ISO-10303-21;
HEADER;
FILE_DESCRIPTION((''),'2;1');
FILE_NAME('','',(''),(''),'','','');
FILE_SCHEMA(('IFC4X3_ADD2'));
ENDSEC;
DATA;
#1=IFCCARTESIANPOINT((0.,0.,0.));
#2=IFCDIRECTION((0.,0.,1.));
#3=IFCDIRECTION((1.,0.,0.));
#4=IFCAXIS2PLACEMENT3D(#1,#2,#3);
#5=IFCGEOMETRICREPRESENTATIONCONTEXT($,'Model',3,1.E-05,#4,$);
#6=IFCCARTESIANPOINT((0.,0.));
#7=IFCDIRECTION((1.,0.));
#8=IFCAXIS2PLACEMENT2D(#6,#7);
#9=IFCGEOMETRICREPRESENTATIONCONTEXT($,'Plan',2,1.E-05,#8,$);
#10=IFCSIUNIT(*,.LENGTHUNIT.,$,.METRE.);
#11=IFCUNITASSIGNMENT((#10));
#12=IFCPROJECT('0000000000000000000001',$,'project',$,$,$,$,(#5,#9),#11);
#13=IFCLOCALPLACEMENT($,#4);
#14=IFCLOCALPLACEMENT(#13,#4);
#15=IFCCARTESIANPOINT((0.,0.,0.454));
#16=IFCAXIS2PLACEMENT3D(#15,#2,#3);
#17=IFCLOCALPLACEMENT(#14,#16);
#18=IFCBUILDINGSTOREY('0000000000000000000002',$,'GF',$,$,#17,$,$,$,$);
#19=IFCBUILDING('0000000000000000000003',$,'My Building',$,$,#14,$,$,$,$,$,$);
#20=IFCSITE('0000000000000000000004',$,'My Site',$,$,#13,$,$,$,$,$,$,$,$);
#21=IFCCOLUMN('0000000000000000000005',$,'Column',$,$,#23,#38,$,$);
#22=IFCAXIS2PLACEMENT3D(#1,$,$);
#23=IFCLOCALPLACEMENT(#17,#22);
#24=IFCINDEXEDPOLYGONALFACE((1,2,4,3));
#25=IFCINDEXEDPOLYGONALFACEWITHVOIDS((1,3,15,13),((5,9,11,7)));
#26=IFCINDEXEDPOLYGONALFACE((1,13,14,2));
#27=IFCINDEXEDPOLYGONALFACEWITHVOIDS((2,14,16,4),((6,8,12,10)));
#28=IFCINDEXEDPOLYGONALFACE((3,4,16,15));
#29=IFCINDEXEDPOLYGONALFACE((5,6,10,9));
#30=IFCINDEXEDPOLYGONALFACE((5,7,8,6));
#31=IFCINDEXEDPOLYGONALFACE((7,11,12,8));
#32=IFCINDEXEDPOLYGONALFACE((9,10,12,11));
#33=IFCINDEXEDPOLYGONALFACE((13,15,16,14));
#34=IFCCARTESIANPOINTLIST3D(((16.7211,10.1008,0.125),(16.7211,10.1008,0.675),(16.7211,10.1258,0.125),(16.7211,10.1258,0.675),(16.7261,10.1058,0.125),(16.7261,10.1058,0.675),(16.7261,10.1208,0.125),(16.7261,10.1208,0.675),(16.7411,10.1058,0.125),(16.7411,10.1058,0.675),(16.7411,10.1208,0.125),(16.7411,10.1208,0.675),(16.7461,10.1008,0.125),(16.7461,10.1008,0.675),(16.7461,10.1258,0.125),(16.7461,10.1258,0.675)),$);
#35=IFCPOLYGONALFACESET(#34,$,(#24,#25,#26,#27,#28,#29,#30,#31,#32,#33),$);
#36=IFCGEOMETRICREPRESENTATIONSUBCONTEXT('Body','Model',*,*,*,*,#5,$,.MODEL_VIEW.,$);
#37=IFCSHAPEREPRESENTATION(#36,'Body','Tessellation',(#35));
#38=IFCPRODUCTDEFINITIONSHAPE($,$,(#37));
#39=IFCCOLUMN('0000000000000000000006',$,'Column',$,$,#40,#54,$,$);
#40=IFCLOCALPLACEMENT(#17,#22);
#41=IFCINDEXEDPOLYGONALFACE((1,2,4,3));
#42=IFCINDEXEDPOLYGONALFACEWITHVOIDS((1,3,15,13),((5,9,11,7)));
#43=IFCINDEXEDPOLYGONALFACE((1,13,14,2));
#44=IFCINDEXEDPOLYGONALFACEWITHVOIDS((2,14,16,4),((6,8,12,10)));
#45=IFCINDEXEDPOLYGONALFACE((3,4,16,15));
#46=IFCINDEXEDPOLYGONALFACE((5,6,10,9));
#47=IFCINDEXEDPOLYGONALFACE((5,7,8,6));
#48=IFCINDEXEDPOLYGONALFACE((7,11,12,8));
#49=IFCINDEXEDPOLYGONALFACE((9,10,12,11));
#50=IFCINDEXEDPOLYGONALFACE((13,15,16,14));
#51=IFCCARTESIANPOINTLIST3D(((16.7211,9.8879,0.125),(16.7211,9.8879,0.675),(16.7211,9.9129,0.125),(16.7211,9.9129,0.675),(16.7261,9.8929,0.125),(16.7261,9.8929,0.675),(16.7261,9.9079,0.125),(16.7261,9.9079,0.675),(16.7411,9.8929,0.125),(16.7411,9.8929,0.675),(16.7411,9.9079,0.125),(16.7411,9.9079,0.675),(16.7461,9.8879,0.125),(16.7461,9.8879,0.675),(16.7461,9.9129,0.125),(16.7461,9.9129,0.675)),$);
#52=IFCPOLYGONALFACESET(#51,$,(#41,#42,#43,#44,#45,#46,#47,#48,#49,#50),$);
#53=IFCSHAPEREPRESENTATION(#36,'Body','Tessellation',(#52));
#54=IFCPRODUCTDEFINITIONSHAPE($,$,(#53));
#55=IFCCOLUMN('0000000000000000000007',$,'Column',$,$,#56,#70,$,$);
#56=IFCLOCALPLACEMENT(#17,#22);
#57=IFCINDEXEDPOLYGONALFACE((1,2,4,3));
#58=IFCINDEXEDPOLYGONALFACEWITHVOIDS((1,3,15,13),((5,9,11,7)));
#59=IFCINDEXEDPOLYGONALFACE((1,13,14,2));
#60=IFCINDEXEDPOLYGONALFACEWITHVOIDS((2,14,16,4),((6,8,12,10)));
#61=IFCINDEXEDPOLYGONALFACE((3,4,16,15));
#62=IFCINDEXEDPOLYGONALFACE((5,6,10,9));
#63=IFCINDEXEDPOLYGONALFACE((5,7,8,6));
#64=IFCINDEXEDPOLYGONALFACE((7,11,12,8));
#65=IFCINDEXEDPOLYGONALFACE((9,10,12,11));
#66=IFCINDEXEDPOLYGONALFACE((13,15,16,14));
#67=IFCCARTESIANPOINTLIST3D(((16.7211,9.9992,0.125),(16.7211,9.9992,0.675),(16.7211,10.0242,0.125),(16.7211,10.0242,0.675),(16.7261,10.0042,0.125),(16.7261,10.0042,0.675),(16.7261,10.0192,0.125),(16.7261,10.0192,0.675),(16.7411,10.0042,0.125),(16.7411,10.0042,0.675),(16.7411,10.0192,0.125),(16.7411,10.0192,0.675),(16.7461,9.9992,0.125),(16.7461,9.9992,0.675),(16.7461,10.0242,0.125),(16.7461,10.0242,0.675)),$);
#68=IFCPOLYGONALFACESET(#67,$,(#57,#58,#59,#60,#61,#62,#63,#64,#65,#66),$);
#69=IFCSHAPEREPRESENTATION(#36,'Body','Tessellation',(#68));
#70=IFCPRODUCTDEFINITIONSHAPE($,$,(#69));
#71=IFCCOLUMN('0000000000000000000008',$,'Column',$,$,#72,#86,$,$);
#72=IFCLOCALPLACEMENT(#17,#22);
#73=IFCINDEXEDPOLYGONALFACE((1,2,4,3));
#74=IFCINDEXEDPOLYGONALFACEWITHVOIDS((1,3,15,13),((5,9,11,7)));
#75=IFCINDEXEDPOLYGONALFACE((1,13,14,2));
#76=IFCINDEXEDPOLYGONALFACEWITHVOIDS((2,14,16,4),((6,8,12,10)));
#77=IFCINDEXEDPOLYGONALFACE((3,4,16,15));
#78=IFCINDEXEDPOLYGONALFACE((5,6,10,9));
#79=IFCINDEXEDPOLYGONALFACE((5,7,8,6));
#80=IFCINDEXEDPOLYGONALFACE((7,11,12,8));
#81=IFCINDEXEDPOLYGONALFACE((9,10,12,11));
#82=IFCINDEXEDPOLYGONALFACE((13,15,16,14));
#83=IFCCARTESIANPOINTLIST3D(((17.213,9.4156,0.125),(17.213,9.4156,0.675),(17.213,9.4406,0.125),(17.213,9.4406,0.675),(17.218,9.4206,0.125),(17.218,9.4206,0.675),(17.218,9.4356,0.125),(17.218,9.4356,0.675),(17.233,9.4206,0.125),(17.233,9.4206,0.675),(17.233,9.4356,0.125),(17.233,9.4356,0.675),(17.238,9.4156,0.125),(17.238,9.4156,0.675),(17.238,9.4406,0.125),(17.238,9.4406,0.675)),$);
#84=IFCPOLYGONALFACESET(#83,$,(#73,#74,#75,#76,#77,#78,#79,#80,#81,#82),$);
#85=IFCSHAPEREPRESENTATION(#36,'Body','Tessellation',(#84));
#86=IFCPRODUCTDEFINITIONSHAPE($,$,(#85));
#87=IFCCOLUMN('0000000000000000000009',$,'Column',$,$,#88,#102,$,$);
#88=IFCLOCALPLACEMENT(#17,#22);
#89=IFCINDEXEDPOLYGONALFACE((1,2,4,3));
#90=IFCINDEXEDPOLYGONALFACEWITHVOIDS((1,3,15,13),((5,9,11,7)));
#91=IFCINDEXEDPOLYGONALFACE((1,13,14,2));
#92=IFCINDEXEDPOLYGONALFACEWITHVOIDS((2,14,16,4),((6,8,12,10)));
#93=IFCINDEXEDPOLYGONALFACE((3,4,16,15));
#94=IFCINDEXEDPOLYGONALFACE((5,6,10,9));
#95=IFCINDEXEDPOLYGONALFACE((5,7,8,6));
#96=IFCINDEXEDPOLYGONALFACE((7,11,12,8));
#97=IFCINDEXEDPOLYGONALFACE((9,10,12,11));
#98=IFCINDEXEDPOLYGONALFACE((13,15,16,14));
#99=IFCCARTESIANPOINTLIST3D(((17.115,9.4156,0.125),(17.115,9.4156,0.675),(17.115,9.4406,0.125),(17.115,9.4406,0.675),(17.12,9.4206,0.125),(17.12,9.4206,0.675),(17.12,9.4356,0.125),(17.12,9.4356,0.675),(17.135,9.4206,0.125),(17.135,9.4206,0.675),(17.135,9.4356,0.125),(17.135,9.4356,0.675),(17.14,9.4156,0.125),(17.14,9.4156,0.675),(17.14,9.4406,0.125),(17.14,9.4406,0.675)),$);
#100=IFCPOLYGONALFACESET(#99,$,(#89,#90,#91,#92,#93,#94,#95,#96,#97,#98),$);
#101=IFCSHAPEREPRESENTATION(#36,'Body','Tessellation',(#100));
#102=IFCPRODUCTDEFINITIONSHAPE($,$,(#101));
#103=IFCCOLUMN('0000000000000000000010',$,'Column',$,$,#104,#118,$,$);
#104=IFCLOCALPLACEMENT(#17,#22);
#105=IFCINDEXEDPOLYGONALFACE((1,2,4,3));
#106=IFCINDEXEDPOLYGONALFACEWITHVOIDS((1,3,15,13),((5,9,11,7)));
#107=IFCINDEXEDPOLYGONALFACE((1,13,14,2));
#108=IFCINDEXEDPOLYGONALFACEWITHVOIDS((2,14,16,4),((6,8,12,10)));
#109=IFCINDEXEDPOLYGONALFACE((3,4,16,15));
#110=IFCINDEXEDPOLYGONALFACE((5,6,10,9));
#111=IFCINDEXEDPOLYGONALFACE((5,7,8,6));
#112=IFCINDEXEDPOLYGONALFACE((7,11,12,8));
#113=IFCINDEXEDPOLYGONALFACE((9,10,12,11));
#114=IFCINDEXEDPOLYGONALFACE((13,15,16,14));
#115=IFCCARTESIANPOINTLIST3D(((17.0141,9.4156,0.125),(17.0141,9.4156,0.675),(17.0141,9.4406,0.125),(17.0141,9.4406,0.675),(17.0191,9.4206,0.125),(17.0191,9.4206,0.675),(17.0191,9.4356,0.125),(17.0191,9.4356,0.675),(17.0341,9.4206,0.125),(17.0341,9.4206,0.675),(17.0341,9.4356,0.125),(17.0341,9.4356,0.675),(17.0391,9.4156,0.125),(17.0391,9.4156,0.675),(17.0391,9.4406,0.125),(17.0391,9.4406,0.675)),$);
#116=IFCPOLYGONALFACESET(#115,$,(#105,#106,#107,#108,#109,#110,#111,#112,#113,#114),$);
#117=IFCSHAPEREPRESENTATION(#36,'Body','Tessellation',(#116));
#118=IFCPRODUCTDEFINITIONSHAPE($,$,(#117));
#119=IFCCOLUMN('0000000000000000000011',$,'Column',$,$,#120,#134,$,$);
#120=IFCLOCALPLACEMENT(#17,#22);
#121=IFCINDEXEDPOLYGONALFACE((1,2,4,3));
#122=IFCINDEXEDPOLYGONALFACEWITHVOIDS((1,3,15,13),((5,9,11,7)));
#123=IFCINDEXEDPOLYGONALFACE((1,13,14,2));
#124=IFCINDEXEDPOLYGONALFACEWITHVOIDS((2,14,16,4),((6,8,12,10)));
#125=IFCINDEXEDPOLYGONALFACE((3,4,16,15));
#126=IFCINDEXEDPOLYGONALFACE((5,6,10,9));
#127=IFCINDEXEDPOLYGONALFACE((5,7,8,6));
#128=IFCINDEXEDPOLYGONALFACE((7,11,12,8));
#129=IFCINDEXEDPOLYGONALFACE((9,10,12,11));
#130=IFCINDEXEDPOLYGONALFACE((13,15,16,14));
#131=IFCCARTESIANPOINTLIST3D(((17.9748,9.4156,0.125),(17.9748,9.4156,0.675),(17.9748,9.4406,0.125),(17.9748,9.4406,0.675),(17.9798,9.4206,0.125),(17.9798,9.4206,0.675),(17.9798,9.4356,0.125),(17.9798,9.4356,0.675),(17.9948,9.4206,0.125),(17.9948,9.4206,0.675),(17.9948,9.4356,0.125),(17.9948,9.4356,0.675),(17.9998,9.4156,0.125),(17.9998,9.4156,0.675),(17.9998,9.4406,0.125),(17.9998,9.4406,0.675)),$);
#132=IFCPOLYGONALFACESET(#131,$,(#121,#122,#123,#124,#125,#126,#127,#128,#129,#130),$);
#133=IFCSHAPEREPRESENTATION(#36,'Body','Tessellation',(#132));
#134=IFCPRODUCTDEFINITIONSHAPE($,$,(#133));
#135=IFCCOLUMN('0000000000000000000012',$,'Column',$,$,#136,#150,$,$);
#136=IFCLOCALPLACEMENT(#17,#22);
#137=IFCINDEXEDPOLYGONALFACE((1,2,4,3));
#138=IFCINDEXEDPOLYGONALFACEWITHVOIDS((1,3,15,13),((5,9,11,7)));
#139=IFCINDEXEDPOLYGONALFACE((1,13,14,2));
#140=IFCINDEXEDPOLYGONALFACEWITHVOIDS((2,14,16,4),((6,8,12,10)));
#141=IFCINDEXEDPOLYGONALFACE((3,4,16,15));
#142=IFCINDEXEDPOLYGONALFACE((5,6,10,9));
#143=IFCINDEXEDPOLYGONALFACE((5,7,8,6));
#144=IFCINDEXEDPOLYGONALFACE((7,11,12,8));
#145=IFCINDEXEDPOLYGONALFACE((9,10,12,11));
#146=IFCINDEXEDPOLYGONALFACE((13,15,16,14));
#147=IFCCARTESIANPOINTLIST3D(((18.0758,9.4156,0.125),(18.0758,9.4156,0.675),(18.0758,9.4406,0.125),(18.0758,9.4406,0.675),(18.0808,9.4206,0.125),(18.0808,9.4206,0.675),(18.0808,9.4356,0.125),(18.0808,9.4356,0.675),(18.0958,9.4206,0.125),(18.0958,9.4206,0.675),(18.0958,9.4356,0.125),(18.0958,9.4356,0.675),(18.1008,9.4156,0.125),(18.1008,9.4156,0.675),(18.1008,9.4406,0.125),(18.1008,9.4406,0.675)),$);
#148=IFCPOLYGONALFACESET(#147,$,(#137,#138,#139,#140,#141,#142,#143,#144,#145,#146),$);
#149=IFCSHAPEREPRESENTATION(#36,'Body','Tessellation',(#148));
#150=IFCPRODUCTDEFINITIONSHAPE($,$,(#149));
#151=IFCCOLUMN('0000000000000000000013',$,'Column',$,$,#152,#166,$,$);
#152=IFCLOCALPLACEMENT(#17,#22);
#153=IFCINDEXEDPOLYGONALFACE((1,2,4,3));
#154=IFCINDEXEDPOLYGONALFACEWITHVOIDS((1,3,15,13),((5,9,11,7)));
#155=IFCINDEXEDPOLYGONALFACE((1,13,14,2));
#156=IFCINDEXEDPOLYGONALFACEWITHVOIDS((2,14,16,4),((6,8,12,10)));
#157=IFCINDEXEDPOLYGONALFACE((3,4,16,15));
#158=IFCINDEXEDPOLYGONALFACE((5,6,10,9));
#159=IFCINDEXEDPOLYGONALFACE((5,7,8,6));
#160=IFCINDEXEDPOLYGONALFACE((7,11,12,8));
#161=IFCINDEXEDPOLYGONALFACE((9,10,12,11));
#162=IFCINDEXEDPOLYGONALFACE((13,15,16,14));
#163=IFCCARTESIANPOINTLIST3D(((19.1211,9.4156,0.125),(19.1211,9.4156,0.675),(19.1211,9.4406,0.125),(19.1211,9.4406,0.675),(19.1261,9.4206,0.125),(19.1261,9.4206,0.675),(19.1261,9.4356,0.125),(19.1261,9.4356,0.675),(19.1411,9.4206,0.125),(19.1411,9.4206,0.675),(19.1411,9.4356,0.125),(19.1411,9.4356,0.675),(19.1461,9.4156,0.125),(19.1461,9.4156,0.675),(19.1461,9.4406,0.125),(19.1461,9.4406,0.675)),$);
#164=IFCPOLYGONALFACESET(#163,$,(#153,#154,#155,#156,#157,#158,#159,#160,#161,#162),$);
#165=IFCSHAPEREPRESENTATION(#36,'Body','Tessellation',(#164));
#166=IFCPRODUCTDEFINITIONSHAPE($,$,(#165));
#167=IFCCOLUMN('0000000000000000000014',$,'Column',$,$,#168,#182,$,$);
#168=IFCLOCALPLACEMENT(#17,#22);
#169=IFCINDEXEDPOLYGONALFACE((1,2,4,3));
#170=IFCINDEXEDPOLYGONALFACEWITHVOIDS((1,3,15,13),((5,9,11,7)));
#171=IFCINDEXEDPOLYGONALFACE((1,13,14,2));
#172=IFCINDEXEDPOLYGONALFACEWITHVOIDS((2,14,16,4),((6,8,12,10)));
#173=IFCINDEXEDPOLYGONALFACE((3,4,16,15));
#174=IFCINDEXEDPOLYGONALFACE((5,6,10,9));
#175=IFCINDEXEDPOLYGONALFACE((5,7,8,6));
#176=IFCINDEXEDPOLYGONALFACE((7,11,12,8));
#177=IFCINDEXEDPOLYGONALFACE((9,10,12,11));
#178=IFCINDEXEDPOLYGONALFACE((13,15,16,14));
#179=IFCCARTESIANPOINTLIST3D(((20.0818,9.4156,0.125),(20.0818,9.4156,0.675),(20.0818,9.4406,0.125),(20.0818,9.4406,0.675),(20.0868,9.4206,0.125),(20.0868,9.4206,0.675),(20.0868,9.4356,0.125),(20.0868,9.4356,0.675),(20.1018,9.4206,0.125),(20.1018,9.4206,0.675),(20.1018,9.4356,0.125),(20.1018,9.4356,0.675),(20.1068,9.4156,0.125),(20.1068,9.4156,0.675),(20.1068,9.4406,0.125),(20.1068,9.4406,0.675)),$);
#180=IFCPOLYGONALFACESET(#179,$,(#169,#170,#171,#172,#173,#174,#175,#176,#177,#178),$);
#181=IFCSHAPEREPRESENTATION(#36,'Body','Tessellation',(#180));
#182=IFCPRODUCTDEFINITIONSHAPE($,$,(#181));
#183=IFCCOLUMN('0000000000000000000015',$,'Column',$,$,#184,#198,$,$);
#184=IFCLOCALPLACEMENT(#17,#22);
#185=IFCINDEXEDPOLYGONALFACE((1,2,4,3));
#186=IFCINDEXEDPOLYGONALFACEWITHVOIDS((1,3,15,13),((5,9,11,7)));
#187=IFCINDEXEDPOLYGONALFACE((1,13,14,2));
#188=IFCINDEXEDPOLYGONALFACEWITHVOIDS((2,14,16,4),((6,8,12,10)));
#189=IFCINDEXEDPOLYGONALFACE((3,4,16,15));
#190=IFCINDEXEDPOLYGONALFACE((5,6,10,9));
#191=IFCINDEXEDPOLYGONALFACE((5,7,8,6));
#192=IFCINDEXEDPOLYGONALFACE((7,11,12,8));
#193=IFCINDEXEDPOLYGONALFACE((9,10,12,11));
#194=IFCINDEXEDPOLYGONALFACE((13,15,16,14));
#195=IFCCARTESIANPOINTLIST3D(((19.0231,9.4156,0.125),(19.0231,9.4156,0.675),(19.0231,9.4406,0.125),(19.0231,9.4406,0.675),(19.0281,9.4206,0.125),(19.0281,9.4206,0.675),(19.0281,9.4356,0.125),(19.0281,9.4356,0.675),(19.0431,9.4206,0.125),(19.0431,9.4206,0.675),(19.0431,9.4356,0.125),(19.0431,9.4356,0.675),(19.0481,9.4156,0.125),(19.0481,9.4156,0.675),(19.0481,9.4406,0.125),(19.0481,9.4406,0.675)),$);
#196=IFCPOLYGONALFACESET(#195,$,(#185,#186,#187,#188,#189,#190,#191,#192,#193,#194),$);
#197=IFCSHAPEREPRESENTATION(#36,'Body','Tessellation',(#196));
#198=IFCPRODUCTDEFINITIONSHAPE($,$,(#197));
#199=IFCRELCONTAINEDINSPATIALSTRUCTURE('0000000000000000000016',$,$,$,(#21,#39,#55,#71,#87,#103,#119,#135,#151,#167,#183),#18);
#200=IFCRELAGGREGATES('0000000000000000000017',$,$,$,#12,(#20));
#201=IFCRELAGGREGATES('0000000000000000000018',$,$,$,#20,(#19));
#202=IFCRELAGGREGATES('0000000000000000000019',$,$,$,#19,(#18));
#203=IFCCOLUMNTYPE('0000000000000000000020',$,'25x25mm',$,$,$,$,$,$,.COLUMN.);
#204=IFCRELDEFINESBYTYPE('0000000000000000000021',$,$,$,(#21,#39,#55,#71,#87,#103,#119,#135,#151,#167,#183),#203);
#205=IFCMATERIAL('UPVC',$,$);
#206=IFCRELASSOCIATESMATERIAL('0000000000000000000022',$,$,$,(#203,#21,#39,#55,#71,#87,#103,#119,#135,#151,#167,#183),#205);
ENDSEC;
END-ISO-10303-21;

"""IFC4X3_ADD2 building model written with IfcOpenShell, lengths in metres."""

from ifc_helpers import new_model, si_unit, frame, origin_with_axes, origin_2d_with_axis, place, context, subcontext, project, spatial, hollow_rectangle, extrude, material, material_profile, profile_set, profile_usage, type_object, element, save


model = new_model("IFC4X3_ADD2")

# Units and contexts
model_context = context("Model", 3, precision=1e-05, world=origin_with_axes())
plan_context = context("Plan", 2, precision=1e-05, world=origin_2d_with_axis())
body_context = subcontext(model_context, "Body", "Model", "MODEL_VIEW")
ifc_project = project(units=[si_unit("LENGTHUNIT", "METRE")], contexts=[model_context, plan_context])

# Site, building, storey
site_placement = place(None, origin_with_axes())
site = spatial("IfcSite", under=ifc_project, at=site_placement, Name="My Site")
building_placement = place(site_placement, origin_with_axes())
building = spatial("IfcBuilding", under=site, at=building_placement, Name="My Building")
storey_placement = place(building_placement, frame((0.0, 0.0, 0.454), z_axis=(0.0, 0.0, 1.0), x_axis=(1.0, 0.0, 0.0)))
storey = spatial("IfcBuildingStorey", under=building, at=storey_placement, Name="GF")

# Columns
ifc_material_1 = material(Name="UPVC")
ifc_material_profile_1 = material_profile(ifc_material_1, hollow_rectangle(XDim=0.025, YDim=0.025, WallThickness=0.005))
ifc_profile_set_1 = profile_set([ifc_material_profile_1])
ifc_profile_usage_1 = profile_usage(ifc_profile_set_1)
column_type_1 = type_object("IfcColumnType", Name="25x25mm", PredefinedType="COLUMN", material=ifc_profile_set_1)
column_1_placement = place(storey_placement, frame((16.7336, 10.1133, 0.125), z_axis=(0.0, 0.0, 1.0), x_axis=(0.0, -1.0, 0.0)))
element("IfcColumn", 1, at=column_1_placement, inside=storey, type_object=column_type_1, material=ifc_profile_usage_1, Name="Column", context=body_context, shape_type="SweptSolid", body=[
    extrude(hollow_rectangle(XDim=0.025, YDim=0.025, WallThickness=0.005), origin_with_axes(), (0.0, 0.0, 1.0), 0.55),
])
ifc_profile_usage_2 = profile_usage(ifc_profile_set_1)
column_2_placement = place(storey_placement, frame((16.7336, 9.9004, 0.125), z_axis=(0.0, 0.0, 1.0), x_axis=(0.0, -1.0, 0.0)))
element("IfcColumn", 2, at=column_2_placement, inside=storey, type_object=column_type_1, material=ifc_profile_usage_2, Name="Column", context=body_context, shape_type="SweptSolid", body=[
    extrude(hollow_rectangle(XDim=0.025, YDim=0.025, WallThickness=0.005), origin_with_axes(), (0.0, 0.0, 1.0), 0.55),
])
ifc_profile_usage_3 = profile_usage(ifc_profile_set_1)
column_3_placement = place(storey_placement, frame((16.7336, 10.0117, 0.125), z_axis=(0.0, 0.0, 1.0), x_axis=(0.0, -1.0, 0.0)))
element("IfcColumn", 3, at=column_3_placement, inside=storey, type_object=column_type_1, material=ifc_profile_usage_3, Name="Column", context=body_context, shape_type="SweptSolid", body=[
    extrude(hollow_rectangle(XDim=0.025, YDim=0.025, WallThickness=0.005), origin_with_axes(), (0.0, 0.0, 1.0), 0.55),
])
ifc_profile_usage_4 = profile_usage(ifc_profile_set_1)
column_4_placement = place(storey_placement, frame((17.2255, 9.4281, 0.125), z_axis=(0.0, 0.0, 1.0), x_axis=(0.0, -1.0, 0.0)))
element("IfcColumn", 4, at=column_4_placement, inside=storey, type_object=column_type_1, material=ifc_profile_usage_4, Name="Column", context=body_context, shape_type="SweptSolid", body=[
    extrude(hollow_rectangle(XDim=0.025, YDim=0.025, WallThickness=0.005), origin_with_axes(), (0.0, 0.0, 1.0), 0.55),
])
ifc_profile_usage_5 = profile_usage(ifc_profile_set_1)
column_5_placement = place(storey_placement, frame((17.1275, 9.4281, 0.125), z_axis=(0.0, 0.0, 1.0), x_axis=(0.0, -1.0, 0.0)))
element("IfcColumn", 5, at=column_5_placement, inside=storey, type_object=column_type_1, material=ifc_profile_usage_5, Name="Column", context=body_context, shape_type="SweptSolid", body=[
    extrude(hollow_rectangle(XDim=0.025, YDim=0.025, WallThickness=0.005), origin_with_axes(), (0.0, 0.0, 1.0), 0.55),
])
ifc_profile_usage_6 = profile_usage(ifc_profile_set_1)
column_6_placement = place(storey_placement, frame((17.0266, 9.4281, 0.125), z_axis=(0.0, 0.0, 1.0), x_axis=(0.0, -1.0, 0.0)))
element("IfcColumn", 6, at=column_6_placement, inside=storey, type_object=column_type_1, material=ifc_profile_usage_6, Name="Column", context=body_context, shape_type="SweptSolid", body=[
    extrude(hollow_rectangle(XDim=0.025, YDim=0.025, WallThickness=0.005), origin_with_axes(), (0.0, 0.0, 1.0), 0.55),
])
ifc_profile_usage_7 = profile_usage(ifc_profile_set_1)
column_7_placement = place(storey_placement, frame((17.9873, 9.4281, 0.125), z_axis=(0.0, 0.0, 1.0), x_axis=(0.0, -1.0, 0.0)))
element("IfcColumn", 7, at=column_7_placement, inside=storey, type_object=column_type_1, material=ifc_profile_usage_7, Name="Column", context=body_context, shape_type="SweptSolid", body=[
    extrude(hollow_rectangle(XDim=0.025, YDim=0.025, WallThickness=0.005), origin_with_axes(), (0.0, 0.0, 1.0), 0.55),
])
ifc_profile_usage_8 = profile_usage(ifc_profile_set_1)
column_8_placement = place(storey_placement, frame((18.0883, 9.4281, 0.125), z_axis=(0.0, 0.0, 1.0), x_axis=(0.0, -1.0, 0.0)))
element("IfcColumn", 8, at=column_8_placement, inside=storey, type_object=column_type_1, material=ifc_profile_usage_8, Name="Column", context=body_context, shape_type="SweptSolid", body=[
    extrude(hollow_rectangle(XDim=0.025, YDim=0.025, WallThickness=0.005), origin_with_axes(), (0.0, 0.0, 1.0), 0.55),
])
ifc_profile_usage_9 = profile_usage(ifc_profile_set_1)
column_9_placement = place(storey_placement, frame((19.1336, 9.4281, 0.125), z_axis=(0.0, 0.0, 1.0), x_axis=(0.0, -1.0, 0.0)))
element("IfcColumn", 9, at=column_9_placement, inside=storey, type_object=column_type_1, material=ifc_profile_usage_9, Name="Column", context=body_context, shape_type="SweptSolid", body=[
    extrude(hollow_rectangle(XDim=0.025, YDim=0.025, WallThickness=0.005), origin_with_axes(), (0.0, 0.0, 1.0), 0.55),
])
ifc_profile_usage_10 = profile_usage(ifc_profile_set_1)
column_10_placement = place(storey_placement, frame((20.0943, 9.4281, 0.125), z_axis=(0.0, 0.0, 1.0), x_axis=(0.0, -1.0, 0.0)))
element("IfcColumn", 10, at=column_10_placement, inside=storey, type_object=column_type_1, material=ifc_profile_usage_10, Name="Column", context=body_context, shape_type="SweptSolid", body=[
    extrude(hollow_rectangle(XDim=0.025, YDim=0.025, WallThickness=0.005), origin_with_axes(), (0.0, 0.0, 1.0), 0.55),
])
ifc_profile_usage_11 = profile_usage(ifc_profile_set_1)
column_11_placement = place(storey_placement, frame((19.0356, 9.4281, 0.125), z_axis=(0.0, 0.0, 1.0), x_axis=(0.0, -1.0, 0.0)))
element("IfcColumn", 11, at=column_11_placement, inside=storey, type_object=column_type_1, material=ifc_profile_usage_11, Name="Column", context=body_context, shape_type="SweptSolid", body=[
    extrude(hollow_rectangle(XDim=0.025, YDim=0.025, WallThickness=0.005), origin_with_axes(), (0.0, 0.0, 1.0), 0.55),
])

save(model, "model.ifc")
